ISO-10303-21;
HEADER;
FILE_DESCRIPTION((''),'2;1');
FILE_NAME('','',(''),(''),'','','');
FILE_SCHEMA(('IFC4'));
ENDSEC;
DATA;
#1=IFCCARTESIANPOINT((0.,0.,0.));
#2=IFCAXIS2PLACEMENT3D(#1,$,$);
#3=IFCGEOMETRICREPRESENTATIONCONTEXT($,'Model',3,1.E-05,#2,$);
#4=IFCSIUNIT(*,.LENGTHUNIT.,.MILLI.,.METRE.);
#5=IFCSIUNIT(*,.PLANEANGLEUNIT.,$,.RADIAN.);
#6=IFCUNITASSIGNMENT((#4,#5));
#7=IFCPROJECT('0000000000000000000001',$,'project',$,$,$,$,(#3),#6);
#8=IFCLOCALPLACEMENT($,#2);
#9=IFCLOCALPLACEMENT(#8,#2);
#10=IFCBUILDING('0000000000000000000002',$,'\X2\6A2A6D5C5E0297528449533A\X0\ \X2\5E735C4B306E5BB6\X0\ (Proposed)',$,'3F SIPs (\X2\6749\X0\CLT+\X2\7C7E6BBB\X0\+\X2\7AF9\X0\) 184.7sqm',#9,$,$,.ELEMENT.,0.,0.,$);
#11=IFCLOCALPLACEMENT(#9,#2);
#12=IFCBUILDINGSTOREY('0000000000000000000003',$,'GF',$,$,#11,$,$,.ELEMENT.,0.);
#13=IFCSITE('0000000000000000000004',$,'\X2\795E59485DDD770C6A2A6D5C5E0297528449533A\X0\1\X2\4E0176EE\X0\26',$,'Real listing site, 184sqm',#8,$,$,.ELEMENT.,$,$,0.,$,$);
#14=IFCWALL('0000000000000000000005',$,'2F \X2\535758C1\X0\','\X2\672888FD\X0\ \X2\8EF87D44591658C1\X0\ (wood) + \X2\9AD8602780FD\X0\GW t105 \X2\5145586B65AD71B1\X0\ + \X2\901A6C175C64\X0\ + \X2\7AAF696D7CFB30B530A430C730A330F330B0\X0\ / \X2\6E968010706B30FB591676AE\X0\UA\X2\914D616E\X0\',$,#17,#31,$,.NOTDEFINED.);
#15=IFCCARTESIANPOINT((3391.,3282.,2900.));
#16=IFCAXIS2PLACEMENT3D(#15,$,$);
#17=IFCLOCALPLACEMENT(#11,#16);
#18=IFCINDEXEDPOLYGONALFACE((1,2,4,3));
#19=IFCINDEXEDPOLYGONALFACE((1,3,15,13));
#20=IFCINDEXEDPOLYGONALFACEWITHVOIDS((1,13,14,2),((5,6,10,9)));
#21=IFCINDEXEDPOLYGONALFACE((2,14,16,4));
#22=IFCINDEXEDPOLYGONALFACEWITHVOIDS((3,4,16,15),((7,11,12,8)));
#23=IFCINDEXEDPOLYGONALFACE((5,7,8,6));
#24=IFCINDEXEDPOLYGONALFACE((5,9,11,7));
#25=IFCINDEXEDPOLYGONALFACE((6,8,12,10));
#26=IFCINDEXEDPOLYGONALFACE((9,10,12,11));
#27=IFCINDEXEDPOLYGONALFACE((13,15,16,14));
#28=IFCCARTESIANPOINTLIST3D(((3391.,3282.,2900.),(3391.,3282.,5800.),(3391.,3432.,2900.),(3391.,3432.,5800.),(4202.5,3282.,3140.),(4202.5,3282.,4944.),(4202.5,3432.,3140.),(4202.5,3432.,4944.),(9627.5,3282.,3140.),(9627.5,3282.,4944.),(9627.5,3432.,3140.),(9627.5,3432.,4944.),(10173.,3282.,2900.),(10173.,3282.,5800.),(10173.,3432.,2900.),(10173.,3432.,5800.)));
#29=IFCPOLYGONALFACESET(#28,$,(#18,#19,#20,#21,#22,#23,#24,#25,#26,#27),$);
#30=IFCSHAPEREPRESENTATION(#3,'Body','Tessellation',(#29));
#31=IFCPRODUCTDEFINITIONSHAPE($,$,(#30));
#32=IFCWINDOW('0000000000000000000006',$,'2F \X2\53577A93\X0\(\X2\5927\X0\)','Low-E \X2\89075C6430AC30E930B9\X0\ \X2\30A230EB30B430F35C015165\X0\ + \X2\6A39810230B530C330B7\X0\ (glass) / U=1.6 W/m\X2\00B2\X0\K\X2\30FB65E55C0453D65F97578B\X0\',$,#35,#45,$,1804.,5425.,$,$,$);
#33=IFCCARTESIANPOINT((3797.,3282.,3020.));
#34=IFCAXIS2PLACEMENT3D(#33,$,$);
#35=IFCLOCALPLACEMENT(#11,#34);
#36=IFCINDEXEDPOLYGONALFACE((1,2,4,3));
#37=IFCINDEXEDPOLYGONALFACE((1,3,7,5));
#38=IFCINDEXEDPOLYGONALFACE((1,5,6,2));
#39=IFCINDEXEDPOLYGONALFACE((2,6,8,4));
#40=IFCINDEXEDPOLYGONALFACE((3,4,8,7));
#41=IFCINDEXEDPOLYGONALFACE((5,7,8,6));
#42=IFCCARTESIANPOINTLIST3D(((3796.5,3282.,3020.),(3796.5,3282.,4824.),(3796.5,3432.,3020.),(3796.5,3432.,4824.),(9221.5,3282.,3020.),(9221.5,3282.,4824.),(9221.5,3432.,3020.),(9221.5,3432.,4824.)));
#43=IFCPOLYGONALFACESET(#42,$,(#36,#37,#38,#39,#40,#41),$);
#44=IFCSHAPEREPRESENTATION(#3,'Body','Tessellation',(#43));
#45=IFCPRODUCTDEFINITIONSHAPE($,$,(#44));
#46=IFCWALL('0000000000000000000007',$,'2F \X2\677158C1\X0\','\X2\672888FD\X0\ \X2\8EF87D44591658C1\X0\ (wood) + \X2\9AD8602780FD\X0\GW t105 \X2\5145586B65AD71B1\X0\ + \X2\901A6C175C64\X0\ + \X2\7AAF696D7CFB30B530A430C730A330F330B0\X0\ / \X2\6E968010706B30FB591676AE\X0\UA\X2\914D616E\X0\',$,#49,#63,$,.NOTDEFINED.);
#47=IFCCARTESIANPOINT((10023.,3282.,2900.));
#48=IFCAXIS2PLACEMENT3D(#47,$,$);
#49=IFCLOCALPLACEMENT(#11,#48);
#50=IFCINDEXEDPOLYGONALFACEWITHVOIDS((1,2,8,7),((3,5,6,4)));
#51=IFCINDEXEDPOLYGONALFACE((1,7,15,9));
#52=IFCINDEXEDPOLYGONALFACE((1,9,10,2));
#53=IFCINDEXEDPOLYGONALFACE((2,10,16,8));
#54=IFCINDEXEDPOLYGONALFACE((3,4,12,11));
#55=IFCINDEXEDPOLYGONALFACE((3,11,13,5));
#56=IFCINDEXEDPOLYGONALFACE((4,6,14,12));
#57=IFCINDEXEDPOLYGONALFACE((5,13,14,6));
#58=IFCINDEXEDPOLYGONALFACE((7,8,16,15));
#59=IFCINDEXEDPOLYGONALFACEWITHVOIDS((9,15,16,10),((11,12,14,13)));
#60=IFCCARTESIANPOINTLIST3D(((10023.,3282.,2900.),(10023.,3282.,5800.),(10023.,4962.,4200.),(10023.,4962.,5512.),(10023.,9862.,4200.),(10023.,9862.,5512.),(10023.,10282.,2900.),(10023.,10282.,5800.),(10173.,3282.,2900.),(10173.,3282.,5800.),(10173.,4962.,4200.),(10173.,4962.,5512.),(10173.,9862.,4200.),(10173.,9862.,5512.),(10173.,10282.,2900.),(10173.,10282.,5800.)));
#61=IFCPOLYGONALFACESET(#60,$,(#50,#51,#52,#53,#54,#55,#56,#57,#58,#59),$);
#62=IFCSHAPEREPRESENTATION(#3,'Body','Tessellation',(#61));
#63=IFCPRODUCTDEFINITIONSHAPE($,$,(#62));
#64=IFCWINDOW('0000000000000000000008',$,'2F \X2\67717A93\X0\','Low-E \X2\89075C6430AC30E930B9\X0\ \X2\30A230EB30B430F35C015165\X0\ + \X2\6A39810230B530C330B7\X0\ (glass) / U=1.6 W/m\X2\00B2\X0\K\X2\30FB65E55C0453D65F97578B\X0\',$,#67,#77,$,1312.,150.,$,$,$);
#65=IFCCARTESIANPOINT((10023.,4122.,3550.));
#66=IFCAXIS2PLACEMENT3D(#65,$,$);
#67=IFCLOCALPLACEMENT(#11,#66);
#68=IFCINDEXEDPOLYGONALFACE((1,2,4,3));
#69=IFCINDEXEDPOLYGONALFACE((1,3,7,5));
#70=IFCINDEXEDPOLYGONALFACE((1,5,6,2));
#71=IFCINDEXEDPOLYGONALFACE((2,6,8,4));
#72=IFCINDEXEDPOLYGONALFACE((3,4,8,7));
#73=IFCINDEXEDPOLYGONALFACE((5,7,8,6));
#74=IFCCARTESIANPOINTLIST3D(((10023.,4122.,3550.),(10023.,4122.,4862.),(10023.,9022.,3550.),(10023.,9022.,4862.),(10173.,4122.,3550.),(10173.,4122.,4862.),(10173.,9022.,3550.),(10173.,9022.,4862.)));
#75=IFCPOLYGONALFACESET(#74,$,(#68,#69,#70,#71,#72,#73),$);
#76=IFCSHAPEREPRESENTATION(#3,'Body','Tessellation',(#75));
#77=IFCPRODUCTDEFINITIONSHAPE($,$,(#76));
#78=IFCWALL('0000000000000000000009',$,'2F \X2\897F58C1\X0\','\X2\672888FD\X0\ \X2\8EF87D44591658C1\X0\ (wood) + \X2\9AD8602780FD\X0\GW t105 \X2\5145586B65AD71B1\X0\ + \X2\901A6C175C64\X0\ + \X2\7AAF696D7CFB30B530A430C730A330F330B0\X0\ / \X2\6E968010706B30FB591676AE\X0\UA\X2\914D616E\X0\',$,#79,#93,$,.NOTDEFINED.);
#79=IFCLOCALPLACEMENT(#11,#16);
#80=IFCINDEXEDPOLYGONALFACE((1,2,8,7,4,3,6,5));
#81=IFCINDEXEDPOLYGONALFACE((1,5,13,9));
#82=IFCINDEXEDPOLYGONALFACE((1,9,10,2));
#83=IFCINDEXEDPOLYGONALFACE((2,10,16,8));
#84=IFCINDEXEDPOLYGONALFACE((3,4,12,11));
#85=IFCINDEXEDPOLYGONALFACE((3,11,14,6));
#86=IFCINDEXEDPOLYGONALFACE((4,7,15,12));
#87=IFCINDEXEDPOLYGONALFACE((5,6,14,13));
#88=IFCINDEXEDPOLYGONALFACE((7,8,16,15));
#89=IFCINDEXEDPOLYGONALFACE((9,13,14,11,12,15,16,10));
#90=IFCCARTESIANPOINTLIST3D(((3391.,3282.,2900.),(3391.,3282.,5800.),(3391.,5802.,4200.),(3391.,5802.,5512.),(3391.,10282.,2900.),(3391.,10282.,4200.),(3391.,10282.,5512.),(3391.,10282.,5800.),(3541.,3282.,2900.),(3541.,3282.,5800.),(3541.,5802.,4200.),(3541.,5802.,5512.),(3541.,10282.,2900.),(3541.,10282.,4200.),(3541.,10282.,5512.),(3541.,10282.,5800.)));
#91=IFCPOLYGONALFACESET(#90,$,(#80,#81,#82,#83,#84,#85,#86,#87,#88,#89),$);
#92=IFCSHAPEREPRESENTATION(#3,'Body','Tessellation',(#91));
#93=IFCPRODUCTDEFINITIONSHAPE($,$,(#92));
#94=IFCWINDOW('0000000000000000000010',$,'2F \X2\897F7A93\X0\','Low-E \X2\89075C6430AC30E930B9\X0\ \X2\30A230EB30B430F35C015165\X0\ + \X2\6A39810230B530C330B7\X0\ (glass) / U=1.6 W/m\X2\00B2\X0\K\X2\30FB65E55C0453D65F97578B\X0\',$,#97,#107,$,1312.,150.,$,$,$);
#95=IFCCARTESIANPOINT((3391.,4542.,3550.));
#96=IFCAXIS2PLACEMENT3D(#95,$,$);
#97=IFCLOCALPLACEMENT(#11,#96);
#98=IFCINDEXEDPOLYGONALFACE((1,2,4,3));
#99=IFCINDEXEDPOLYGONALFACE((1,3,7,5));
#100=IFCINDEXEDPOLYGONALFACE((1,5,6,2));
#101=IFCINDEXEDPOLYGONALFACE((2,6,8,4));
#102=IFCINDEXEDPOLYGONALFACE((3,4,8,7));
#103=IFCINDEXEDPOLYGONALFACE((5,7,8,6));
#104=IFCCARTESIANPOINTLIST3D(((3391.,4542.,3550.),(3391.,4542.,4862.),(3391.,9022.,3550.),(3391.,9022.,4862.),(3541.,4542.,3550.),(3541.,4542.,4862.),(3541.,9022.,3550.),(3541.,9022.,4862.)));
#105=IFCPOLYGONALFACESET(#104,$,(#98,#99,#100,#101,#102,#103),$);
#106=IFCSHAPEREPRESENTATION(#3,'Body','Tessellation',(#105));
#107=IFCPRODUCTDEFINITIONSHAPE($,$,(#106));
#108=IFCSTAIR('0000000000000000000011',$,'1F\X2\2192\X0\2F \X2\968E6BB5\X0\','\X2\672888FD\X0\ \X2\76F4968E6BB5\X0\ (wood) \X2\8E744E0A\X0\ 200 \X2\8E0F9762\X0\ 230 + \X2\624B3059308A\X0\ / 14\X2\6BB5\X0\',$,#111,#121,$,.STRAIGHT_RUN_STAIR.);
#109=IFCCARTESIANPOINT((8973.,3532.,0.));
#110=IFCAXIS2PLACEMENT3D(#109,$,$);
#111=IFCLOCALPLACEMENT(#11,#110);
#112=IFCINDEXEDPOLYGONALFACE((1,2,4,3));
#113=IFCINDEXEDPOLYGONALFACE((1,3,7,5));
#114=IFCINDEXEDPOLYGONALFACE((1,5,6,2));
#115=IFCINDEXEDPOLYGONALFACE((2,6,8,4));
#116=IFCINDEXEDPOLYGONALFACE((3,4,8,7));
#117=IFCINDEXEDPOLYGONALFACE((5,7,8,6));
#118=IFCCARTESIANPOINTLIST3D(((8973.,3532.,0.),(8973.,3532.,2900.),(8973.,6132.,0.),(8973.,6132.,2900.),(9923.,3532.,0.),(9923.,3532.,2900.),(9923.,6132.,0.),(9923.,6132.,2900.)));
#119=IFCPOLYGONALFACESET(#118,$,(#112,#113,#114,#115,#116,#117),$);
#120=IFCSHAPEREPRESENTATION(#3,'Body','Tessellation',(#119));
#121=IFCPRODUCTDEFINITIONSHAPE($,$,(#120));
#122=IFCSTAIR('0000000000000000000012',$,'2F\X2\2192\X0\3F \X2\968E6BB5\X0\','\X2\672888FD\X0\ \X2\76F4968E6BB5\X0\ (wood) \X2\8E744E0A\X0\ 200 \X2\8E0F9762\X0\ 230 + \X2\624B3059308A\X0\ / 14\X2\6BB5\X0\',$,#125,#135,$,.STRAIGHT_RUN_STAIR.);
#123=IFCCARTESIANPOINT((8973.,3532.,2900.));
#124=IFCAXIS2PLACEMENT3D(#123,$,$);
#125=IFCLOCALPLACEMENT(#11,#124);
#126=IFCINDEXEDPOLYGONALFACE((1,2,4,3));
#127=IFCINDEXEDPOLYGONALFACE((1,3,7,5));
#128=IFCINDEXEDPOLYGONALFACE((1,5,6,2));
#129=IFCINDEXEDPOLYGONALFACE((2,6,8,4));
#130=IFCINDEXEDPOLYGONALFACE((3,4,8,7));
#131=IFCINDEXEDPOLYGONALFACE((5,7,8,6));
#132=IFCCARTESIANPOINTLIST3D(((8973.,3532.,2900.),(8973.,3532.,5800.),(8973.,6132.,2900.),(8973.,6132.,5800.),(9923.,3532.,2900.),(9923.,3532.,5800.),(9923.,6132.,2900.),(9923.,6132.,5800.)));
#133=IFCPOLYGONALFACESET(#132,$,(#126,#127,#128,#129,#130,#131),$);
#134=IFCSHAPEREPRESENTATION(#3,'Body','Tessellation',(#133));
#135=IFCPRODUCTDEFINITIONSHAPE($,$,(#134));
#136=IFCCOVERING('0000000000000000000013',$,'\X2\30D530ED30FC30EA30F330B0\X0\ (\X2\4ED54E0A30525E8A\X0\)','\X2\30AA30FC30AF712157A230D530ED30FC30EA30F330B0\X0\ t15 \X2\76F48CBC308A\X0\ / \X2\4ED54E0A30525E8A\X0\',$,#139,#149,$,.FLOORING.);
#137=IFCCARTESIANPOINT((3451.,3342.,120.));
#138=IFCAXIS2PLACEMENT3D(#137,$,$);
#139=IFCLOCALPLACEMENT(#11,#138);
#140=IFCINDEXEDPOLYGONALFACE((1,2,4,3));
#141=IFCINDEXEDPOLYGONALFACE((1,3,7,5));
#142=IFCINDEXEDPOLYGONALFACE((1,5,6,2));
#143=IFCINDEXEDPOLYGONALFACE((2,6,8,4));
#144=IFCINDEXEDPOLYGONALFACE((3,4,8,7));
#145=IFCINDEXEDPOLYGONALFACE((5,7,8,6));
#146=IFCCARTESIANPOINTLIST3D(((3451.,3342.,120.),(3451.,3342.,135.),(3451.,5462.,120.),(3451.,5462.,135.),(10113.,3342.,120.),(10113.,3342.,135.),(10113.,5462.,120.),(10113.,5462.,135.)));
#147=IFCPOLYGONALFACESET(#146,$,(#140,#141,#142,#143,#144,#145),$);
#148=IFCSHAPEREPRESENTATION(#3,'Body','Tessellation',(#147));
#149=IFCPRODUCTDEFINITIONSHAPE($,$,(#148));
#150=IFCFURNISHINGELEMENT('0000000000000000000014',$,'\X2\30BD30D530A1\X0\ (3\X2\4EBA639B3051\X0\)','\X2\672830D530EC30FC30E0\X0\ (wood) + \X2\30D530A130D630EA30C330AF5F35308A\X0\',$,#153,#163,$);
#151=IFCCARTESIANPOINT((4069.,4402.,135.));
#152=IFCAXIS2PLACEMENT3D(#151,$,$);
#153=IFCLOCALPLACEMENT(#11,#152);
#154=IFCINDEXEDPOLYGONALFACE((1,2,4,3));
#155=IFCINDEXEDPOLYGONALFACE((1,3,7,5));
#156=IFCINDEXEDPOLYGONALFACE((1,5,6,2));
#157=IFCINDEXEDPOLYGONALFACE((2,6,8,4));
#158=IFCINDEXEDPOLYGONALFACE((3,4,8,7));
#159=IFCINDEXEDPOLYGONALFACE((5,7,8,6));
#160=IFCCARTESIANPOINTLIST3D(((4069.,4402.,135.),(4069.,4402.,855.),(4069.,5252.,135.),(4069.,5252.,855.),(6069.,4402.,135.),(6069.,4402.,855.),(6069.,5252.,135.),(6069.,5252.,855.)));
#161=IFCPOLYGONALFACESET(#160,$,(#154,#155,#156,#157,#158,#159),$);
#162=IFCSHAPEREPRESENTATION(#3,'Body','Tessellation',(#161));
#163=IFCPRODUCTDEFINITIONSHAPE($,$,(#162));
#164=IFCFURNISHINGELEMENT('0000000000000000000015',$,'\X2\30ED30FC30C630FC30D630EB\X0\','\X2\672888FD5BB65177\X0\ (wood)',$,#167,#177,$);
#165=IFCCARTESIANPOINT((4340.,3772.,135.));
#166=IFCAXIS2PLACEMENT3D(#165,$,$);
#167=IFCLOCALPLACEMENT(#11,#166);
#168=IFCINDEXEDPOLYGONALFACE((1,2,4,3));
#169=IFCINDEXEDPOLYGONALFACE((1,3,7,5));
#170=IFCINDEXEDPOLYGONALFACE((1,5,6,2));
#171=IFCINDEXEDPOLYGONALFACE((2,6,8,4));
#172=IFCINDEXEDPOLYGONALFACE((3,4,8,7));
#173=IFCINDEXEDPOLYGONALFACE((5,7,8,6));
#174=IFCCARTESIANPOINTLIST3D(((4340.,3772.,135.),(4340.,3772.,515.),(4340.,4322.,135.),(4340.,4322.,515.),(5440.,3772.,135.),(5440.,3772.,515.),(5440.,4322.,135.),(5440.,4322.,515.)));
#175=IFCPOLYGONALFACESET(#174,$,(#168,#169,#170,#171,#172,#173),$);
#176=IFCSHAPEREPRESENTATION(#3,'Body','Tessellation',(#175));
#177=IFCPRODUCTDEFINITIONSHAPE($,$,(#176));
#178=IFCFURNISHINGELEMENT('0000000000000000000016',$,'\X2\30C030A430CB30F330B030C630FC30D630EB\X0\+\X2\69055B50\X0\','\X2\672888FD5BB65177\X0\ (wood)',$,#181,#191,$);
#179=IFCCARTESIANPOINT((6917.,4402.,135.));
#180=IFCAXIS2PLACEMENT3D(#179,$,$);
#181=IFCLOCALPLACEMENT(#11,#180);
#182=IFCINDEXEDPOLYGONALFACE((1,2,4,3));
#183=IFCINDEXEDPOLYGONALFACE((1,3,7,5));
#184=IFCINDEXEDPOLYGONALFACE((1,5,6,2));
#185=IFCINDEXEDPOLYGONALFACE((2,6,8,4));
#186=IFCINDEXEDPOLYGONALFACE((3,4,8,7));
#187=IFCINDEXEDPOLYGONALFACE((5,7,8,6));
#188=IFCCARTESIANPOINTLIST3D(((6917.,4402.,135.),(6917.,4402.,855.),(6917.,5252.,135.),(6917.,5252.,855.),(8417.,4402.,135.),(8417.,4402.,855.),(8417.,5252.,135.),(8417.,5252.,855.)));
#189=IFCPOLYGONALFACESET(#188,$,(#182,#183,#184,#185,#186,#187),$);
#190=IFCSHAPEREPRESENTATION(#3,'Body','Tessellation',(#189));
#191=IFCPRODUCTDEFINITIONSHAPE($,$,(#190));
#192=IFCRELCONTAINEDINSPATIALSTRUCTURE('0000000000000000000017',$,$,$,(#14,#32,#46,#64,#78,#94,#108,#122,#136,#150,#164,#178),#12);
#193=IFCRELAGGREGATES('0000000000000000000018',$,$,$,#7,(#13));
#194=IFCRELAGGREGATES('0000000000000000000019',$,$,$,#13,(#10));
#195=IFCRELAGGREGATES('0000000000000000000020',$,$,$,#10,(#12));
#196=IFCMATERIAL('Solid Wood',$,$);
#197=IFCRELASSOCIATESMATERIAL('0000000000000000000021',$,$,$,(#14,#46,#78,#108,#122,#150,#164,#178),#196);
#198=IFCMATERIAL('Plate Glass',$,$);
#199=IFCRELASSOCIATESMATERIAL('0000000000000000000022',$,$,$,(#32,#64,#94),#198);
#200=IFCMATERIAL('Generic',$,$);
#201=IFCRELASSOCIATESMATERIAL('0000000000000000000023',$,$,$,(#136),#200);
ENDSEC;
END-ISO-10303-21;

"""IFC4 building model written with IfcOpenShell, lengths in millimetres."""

from ifc_helpers import new_model, si_unit, frame, frame_2d, origin, place, context, project, spatial, rectangle, extrude, material, element, fill, save


model = new_model("IFC4")

# Units and contexts
model_context = context("Model", 3, precision=1e-05, world=origin())
ifc_project = project(units=[si_unit("LENGTHUNIT", "METRE", prefix="MILLI"), si_unit("PLANEANGLEUNIT", "RADIAN")], contexts=[model_context])

# Site, building, storey
site_placement = place(None, origin())
site = spatial("IfcSite", under=ifc_project, at=site_placement, Name="神奈川県横浜市青葉区1丁目26", ObjectType="Real listing site, 184sqm", CompositionType="ELEMENT", RefElevation=0.0)
building_placement = place(site_placement, origin())
building = spatial("IfcBuilding", under=site, at=building_placement, Name="横浜市青葉区 平屋の家 (Proposed)", ObjectType="3F SIPs (杉CLT+籾殻+竹) 184.7sqm", CompositionType="ELEMENT", ElevationOfRefHeight=0.0, ElevationOfTerrain=0.0)
storey_placement = place(building_placement, origin())
storey = spatial("IfcBuildingStorey", under=building, at=storey_placement, Name="GF", CompositionType="ELEMENT", Elevation=0.0)

# Shared definitions
ifc_material_1 = material(Name="Solid Wood")
ifc_material_2 = material(Name="Generic")

# Shared definitions
ifc_material_3 = material(Name="Plate Glass")

# Walls, openings, windows
wall_1_placement = place(storey_placement, frame((3391.0, 3282.0, 2900.0)))
wall_1 = element("IfcWall", 1, at=wall_1_placement, inside=storey, material=ifc_material_1, Name="2F 南壁", Description="木製 軸組外壁 (wood) + 高性能GW t105 充填断熱 + 通気層 + 窯業系サイディング / 準耐火・外皮UA配慮", PredefinedType="NOTDEFINED", context=model_context, shape_type="SweptSolid", body=[
    extrude(rectangle(XDim=6782.0, YDim=150.0, at=frame_2d((3391.0, 75.0))), frame((3391.0, 3282.0, 2900.0)), (0.0, 0.0, 1.0), 2900.0),
])
opening_1_placement = place(storey_placement, frame((3797.0, 3282.0, 3020.0)))
opening_1 = element("IfcOpeningElement", 2, at=opening_1_placement, cuts=wall_1, PredefinedType="NOTDEFINED", context=model_context, shape_type="SweptSolid", body=[
    extrude(rectangle(XDim=5425.0, YDim=150.0, at=frame_2d((2712.0, 75.0))), frame((3797.0, 3282.0, 3020.0)), (0.0, 0.0, 1.0), 1804.0),
])
window_1_placement = place(storey_placement, frame((3797.0, 3282.0, 3020.0)))
window_1 = element("IfcWindow", 3, at=window_1_placement, inside=storey, material=ifc_material_3, Name="2F 南窓(大)", Description="Low-E 複層ガラス アルゴン封入 + 樹脂サッシ (glass) / U=1.6 W/m²K・日射取得型", OverallHeight=1804.0, OverallWidth=5425.0, context=model_context, shape_type="SweptSolid", body=[
    extrude(rectangle(XDim=5425.0, YDim=150.0, at=frame_2d((2712.0, 75.0))), frame((3797.0, 3282.0, 3020.0)), (0.0, 0.0, 1.0), 1804.0),
])
fill(opening_1, window_1)
wall_2_placement = place(storey_placement, frame((10023.0, 3282.0, 2900.0)))
wall_2 = element("IfcWall", 4, at=wall_2_placement, inside=storey, material=ifc_material_1, Name="2F 東壁", Description="木製 軸組外壁 (wood) + 高性能GW t105 充填断熱 + 通気層 + 窯業系サイディング / 準耐火・外皮UA配慮", PredefinedType="NOTDEFINED", context=model_context, shape_type="SweptSolid", body=[
    extrude(rectangle(XDim=150.0, YDim=7000.0, at=frame_2d((75.0, 3500.0))), frame((10023.0, 3282.0, 2900.0)), (0.0, 0.0, 1.0), 2900.0),
])
opening_2_placement = place(storey_placement, frame((10023.0, 4122.0, 3550.0)))
opening_2 = element("IfcOpeningElement", 5, at=opening_2_placement, cuts=wall_2, PredefinedType="NOTDEFINED", context=model_context, shape_type="SweptSolid", body=[
    extrude(rectangle(XDim=150.0, YDim=4900.0, at=frame_2d((75.0, 2450.0))), frame((10023.0, 4122.0, 3550.0)), (0.0, 0.0, 1.0), 1312.0),
])
window_2_placement = place(storey_placement, frame((10023.0, 4122.0, 3550.0)))
window_2 = element("IfcWindow", 6, at=window_2_placement, inside=storey, material=ifc_material_3, Name="2F 東窓", Description="Low-E 複層ガラス アルゴン封入 + 樹脂サッシ (glass) / U=1.6 W/m²K・日射取得型", OverallHeight=1312.0, OverallWidth=150.0, context=model_context, shape_type="SweptSolid", body=[
    extrude(rectangle(XDim=150.0, YDim=4900.0, at=frame_2d((75.0, 2450.0))), frame((10023.0, 4122.0, 3550.0)), (0.0, 0.0, 1.0), 1312.0),
])
fill(opening_2, window_2)
wall_3_placement = place(storey_placement, frame((3391.0, 3282.0, 2900.0)))
wall_3 = element("IfcWall", 7, at=wall_3_placement, inside=storey, material=ifc_material_1, Name="2F 西壁", Description="木製 軸組外壁 (wood) + 高性能GW t105 充填断熱 + 通気層 + 窯業系サイディング / 準耐火・外皮UA配慮", PredefinedType="NOTDEFINED", context=model_context, shape_type="SweptSolid", body=[
    extrude(rectangle(XDim=150.0, YDim=7000.0, at=frame_2d((75.0, 3500.0))), frame((3391.0, 3282.0, 2900.0)), (0.0, 0.0, 1.0), 2900.0),
])
opening_3_placement = place(storey_placement, frame((3391.0, 4542.0, 3550.0)))
opening_3 = element("IfcOpeningElement", 8, at=opening_3_placement, cuts=wall_3, PredefinedType="NOTDEFINED", context=model_context, shape_type="SweptSolid", body=[
    extrude(rectangle(XDim=150.0, YDim=4480.0, at=frame_2d((75.0, 2240.0))), frame((3391.0, 4542.0, 3550.0)), (0.0, 0.0, 1.0), 1312.0),
])
window_3_placement = place(storey_placement, frame((3391.0, 4542.0, 3550.0)))
window_3 = element("IfcWindow", 9, at=window_3_placement, inside=storey, material=ifc_material_3, Name="2F 西窓", Description="Low-E 複層ガラス アルゴン封入 + 樹脂サッシ (glass) / U=1.6 W/m²K・日射取得型", OverallHeight=1312.0, OverallWidth=150.0, context=model_context, shape_type="SweptSolid", body=[
    extrude(rectangle(XDim=150.0, YDim=4480.0, at=frame_2d((75.0, 2240.0))), frame((3391.0, 4542.0, 3550.0)), (0.0, 0.0, 1.0), 1312.0),
])
fill(opening_3, window_3)

# Stairs
stair_1_placement = place(storey_placement, frame((8973.0, 3532.0, 0.0)))
element("IfcStair", 10, at=stair_1_placement, inside=storey, material=ifc_material_1, Name="1F→2F 階段", Description="木製 直階段 (wood) 蹴上 200 踏面 230 + 手すり / 14段", PredefinedType="STRAIGHT_RUN_STAIR", context=model_context, shape_type="SweptSolid", body=[
    extrude(rectangle(XDim=950.0, YDim=2600.0, at=frame_2d((475.0, 1300.0))), frame((8973.0, 3532.0, 0.0)), (0.0, 0.0, 1.0), 2900.0),
])
stair_2_placement = place(storey_placement, frame((8973.0, 3532.0, 2900.0)))
element("IfcStair", 11, at=stair_2_placement, inside=storey, material=ifc_material_1, Name="2F→3F 階段", Description="木製 直階段 (wood) 蹴上 200 踏面 230 + 手すり / 14段", PredefinedType="STRAIGHT_RUN_STAIR", context=model_context, shape_type="SweptSolid", body=[
    extrude(rectangle(XDim=950.0, YDim=2600.0, at=frame_2d((475.0, 1300.0))), frame((8973.0, 3532.0, 2900.0)), (0.0, 0.0, 1.0), 2900.0),
])

# Covering
covering_placement = place(storey_placement, frame((3451.0, 3342.0, 120.0)))
element("IfcCovering", 12, at=covering_placement, inside=storey, material=ifc_material_2, Name="フローリング (仕上げ床)", Description="オーク無垢フローリング t15 直貼り / 仕上げ床", PredefinedType="FLOORING", context=model_context, shape_type="SweptSolid", body=[
    extrude(rectangle(XDim=6662.0, YDim=2120.0, at=frame_2d((3331.0, 1060.0))), frame((3451.0, 3342.0, 120.0)), (0.0, 0.0, 1.0), 15.0),
])

# Furnishing elements
furnishing_1_placement = place(storey_placement, frame((4069.0, 4402.0, 135.0)))
element("IfcFurnishingElement", 13, at=furnishing_1_placement, inside=storey, material=ifc_material_1, Name="ソファ (3人掛け)", Description="木フレーム (wood) + ファブリック張り", context=model_context, shape_type="SweptSolid", body=[
    extrude(rectangle(XDim=2000.0, YDim=850.0, at=frame_2d((1000.0, 425.0))), frame((4069.0, 4402.0, 135.0)), (0.0, 0.0, 1.0), 720.0),
])
furnishing_2_placement = place(storey_placement, frame((4340.0, 3772.0, 135.0)))
element("IfcFurnishingElement", 14, at=furnishing_2_placement, inside=storey, material=ifc_material_1, Name="ローテーブル", Description="木製家具 (wood)", context=model_context, shape_type="SweptSolid", body=[
    extrude(rectangle(XDim=1100.0, YDim=550.0, at=frame_2d((550.0, 275.0))), frame((4340.0, 3772.0, 135.0)), (0.0, 0.0, 1.0), 380.0),
])
furnishing_3_placement = place(storey_placement, frame((6917.0, 4402.0, 135.0)))
element("IfcFurnishingElement", 15, at=furnishing_3_placement, inside=storey, material=ifc_material_1, Name="ダイニングテーブル+椅子", Description="木製家具 (wood)", context=model_context, shape_type="SweptSolid", body=[
    extrude(rectangle(XDim=1500.0, YDim=850.0, at=frame_2d((750.0, 425.0))), frame((6917.0, 4402.0, 135.0)), (0.0, 0.0, 1.0), 720.0),
])

save(model, "model.ifc")
